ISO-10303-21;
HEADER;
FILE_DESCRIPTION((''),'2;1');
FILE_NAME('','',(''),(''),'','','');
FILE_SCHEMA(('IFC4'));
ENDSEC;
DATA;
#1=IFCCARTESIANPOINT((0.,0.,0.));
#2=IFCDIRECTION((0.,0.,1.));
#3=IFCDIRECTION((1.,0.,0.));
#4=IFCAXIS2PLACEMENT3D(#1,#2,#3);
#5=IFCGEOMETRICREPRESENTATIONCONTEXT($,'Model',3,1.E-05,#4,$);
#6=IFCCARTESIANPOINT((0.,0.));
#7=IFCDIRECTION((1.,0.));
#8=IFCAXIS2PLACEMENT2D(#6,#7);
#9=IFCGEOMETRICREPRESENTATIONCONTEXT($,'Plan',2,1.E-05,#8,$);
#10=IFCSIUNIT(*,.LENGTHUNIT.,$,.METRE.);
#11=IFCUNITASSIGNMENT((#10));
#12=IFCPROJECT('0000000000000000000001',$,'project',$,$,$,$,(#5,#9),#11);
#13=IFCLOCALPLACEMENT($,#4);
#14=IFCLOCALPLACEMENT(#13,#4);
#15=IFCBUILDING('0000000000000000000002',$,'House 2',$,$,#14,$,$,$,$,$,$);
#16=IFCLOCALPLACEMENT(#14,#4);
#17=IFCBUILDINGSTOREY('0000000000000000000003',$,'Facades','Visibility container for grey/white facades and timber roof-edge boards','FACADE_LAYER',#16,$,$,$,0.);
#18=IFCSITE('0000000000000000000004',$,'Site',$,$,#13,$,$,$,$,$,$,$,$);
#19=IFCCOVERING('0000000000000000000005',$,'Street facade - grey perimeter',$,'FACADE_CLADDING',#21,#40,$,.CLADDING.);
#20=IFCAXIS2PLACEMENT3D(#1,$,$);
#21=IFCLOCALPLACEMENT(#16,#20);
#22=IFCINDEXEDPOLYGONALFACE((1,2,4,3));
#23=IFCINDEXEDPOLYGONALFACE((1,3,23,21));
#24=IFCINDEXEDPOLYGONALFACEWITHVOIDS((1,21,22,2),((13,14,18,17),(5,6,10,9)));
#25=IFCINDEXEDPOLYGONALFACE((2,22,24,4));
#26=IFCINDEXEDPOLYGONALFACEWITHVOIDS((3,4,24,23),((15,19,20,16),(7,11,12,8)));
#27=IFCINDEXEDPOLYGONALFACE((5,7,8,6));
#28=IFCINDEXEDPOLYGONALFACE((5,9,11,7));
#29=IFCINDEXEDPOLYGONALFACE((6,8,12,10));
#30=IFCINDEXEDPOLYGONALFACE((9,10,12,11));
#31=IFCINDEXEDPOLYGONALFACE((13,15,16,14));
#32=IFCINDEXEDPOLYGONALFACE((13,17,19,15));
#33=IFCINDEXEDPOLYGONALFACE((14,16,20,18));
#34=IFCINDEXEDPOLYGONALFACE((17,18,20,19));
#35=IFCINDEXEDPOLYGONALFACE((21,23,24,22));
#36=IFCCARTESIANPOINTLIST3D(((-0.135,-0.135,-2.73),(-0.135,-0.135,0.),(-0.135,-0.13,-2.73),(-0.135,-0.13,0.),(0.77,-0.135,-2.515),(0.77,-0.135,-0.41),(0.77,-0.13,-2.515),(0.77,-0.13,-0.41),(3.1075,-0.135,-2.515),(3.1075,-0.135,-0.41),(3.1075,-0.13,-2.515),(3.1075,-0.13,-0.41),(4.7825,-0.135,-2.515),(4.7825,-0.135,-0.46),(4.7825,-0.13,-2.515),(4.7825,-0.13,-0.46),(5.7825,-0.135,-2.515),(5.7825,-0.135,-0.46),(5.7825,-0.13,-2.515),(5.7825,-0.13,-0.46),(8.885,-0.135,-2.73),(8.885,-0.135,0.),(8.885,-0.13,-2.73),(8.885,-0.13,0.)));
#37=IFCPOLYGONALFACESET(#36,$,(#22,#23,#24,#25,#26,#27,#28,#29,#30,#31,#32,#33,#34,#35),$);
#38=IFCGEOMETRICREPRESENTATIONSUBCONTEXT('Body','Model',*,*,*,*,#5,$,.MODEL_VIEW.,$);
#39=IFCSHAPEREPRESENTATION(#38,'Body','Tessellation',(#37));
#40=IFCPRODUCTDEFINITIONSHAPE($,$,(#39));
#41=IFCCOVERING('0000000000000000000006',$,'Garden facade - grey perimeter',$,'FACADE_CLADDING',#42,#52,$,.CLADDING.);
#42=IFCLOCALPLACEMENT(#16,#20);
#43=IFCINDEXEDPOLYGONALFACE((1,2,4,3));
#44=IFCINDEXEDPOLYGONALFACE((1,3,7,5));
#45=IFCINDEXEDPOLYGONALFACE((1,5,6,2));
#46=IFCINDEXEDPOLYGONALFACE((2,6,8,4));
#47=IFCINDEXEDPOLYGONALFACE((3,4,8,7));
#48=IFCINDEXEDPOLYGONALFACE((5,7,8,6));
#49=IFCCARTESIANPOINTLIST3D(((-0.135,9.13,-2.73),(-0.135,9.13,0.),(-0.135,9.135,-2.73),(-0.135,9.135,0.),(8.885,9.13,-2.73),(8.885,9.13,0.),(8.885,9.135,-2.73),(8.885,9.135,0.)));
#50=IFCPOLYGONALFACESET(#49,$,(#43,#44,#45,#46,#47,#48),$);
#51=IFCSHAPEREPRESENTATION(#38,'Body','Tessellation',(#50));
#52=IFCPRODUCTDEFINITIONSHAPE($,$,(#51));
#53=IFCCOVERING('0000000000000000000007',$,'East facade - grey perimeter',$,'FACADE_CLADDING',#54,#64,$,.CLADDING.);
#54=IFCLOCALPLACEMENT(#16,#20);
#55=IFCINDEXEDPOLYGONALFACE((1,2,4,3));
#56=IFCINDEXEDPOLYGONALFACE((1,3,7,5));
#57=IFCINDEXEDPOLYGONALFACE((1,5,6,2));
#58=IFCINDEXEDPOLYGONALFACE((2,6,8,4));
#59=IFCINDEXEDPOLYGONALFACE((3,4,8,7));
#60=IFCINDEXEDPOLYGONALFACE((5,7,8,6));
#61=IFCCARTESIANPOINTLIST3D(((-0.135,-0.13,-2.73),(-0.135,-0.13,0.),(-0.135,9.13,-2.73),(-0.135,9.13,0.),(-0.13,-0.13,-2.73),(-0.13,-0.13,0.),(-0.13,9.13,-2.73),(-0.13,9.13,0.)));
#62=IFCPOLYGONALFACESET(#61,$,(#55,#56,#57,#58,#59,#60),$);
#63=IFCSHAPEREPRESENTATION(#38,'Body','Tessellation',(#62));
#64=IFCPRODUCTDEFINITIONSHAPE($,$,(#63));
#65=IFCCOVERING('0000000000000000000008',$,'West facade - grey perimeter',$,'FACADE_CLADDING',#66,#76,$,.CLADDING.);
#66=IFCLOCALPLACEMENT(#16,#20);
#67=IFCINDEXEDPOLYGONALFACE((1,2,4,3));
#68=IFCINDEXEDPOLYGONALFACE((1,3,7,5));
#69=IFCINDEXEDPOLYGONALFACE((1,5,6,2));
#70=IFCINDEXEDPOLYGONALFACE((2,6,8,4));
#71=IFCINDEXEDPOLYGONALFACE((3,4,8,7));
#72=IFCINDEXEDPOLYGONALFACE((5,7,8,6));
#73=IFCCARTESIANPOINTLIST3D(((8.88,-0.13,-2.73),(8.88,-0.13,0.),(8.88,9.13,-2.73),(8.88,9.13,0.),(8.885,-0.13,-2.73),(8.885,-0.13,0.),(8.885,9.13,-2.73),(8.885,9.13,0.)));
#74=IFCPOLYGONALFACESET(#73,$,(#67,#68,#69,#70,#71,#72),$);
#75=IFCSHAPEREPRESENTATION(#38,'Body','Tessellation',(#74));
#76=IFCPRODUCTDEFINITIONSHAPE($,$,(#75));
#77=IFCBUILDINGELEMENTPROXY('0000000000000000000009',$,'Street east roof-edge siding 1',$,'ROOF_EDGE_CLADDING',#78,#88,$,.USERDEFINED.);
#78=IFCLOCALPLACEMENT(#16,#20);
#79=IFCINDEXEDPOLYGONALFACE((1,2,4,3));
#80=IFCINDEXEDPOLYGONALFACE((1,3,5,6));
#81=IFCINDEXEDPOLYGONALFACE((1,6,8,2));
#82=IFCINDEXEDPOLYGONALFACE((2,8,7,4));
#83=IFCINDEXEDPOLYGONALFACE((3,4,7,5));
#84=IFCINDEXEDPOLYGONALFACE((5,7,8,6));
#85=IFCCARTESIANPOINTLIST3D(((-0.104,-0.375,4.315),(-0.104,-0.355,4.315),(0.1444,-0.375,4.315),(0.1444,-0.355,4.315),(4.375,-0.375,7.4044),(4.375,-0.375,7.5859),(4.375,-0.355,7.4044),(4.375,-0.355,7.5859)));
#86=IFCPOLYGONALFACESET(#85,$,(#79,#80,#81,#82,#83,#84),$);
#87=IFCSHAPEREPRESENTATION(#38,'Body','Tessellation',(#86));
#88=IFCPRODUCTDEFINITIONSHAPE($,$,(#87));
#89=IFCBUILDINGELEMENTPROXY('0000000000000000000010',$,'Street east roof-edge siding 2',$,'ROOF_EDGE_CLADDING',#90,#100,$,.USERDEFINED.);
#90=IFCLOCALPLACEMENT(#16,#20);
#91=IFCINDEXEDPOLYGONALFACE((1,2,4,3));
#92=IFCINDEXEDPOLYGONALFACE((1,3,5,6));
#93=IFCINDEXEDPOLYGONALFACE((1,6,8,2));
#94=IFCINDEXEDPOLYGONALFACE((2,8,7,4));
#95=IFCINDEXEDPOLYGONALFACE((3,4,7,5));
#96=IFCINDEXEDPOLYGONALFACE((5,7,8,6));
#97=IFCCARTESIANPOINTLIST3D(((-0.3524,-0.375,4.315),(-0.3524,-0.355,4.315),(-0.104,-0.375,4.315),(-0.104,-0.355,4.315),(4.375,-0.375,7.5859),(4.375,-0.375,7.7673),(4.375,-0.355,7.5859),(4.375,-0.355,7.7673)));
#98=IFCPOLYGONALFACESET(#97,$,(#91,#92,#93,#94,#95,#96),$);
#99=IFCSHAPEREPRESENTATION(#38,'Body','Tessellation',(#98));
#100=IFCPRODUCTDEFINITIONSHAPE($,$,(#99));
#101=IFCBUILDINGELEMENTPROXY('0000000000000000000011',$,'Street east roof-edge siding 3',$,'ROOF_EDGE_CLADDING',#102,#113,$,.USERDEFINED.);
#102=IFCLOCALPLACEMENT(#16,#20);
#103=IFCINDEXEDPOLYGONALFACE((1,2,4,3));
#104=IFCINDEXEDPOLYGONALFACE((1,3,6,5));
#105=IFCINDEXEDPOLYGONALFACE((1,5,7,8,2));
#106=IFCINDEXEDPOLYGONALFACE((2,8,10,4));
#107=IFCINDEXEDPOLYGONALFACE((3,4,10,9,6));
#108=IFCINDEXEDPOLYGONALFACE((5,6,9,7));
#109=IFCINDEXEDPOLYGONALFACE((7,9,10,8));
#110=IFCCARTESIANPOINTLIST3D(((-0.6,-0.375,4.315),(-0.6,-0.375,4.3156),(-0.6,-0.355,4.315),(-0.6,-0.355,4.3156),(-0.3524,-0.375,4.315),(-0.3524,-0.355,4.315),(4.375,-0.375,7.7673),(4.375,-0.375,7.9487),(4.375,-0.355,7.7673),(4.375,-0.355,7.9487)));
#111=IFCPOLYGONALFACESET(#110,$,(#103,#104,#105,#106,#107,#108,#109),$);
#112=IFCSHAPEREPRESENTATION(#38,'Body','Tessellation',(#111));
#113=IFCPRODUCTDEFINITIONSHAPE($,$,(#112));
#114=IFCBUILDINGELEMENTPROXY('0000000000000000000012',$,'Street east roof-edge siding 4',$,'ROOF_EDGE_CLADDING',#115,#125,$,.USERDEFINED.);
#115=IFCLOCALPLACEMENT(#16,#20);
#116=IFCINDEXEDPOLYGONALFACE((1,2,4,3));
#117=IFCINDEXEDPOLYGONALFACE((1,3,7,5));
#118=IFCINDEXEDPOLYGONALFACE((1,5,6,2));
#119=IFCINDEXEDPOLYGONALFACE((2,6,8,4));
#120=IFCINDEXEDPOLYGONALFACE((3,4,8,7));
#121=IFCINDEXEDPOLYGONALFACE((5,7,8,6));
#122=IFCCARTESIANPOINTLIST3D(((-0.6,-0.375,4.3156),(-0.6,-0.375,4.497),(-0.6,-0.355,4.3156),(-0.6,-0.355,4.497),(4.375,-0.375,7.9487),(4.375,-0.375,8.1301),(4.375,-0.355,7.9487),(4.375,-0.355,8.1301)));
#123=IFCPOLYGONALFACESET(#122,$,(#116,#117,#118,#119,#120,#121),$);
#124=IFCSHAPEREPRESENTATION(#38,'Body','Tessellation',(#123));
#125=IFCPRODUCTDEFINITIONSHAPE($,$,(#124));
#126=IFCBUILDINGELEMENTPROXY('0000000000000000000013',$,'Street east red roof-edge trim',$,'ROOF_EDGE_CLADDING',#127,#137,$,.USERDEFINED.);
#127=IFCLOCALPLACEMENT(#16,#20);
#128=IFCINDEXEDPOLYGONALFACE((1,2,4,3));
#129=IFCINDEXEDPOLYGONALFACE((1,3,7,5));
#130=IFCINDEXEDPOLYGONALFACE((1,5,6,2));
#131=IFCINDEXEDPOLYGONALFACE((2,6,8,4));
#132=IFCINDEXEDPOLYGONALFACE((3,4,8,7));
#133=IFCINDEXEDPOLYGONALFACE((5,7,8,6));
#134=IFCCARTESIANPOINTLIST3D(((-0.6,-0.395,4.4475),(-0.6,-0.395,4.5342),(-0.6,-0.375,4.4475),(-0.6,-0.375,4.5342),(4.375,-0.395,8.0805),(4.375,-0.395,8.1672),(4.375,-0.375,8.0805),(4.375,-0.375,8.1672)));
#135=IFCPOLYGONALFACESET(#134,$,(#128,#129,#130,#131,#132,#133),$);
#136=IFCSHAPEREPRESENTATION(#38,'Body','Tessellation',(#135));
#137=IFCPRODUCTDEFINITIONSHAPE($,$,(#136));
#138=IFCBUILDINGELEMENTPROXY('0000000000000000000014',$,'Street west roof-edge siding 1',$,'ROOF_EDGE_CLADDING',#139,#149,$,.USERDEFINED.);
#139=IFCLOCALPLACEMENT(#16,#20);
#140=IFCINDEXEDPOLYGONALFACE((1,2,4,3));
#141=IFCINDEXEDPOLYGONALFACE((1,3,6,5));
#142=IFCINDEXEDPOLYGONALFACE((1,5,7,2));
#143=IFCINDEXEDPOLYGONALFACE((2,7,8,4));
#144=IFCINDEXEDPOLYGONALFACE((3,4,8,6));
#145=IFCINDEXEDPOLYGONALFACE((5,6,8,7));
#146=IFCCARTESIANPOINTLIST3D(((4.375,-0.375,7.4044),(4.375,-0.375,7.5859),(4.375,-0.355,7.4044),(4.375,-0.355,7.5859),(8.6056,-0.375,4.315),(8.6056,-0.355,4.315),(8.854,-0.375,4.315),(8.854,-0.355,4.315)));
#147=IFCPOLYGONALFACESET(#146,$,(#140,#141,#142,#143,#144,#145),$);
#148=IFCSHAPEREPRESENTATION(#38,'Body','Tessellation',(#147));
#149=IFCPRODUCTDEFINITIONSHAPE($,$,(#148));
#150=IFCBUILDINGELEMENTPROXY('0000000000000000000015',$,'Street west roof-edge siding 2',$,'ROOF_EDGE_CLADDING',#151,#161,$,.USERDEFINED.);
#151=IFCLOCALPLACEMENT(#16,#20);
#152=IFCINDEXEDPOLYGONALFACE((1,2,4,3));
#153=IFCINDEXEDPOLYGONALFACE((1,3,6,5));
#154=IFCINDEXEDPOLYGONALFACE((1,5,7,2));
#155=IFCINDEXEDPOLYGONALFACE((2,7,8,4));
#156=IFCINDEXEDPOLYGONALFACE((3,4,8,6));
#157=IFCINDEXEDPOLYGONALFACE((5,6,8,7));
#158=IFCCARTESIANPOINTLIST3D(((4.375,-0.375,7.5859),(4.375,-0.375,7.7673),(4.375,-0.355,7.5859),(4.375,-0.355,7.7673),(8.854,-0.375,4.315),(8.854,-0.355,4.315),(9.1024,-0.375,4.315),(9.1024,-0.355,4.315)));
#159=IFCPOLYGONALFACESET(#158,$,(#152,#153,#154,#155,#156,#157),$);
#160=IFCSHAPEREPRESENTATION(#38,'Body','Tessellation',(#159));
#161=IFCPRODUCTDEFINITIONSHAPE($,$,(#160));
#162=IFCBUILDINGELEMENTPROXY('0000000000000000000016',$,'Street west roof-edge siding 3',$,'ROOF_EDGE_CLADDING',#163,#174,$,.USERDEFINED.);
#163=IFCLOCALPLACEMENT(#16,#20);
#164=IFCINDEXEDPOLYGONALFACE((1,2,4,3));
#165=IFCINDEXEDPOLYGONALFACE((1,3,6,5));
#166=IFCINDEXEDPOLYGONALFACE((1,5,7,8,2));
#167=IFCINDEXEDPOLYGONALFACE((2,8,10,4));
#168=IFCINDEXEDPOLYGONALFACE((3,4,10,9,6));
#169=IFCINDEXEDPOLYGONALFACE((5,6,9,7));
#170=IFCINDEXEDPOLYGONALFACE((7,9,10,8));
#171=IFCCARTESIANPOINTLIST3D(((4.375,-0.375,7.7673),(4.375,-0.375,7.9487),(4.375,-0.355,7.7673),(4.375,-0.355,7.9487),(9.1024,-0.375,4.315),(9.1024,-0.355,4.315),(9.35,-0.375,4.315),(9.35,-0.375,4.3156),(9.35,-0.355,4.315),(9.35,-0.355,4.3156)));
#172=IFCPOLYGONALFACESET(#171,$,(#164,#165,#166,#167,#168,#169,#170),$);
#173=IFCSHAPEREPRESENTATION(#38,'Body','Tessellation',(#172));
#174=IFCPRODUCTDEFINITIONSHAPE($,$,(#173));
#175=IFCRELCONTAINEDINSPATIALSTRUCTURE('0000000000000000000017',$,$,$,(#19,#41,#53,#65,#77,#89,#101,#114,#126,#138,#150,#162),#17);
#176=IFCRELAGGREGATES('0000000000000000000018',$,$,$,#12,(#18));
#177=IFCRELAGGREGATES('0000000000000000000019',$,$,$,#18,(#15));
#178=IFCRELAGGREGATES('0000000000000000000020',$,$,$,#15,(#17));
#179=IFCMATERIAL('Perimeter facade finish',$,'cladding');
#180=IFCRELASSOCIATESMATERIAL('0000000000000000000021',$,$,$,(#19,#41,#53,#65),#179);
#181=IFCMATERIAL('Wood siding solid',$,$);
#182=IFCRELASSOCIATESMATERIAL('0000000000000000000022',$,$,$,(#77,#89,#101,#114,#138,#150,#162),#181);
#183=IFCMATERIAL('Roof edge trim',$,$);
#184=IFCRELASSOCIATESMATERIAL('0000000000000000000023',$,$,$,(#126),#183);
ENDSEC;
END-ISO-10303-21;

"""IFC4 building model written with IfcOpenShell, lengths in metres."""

from ifc_helpers import new_model, si_unit, frame, origin_with_axes, origin_2d_with_axis, place, context, subcontext, project, spatial, line, indexed_curve, outline, extrude, material, element, save


model = new_model("IFC4")

# Units and contexts
model_context = context("Model", 3, precision=1e-05, world=origin_with_axes())
plan_context = context("Plan", 2, precision=1e-05, world=origin_2d_with_axis())
body_context = subcontext(model_context, "Body", "Model", "MODEL_VIEW")
ifc_project = project(units=[si_unit("LENGTHUNIT", "METRE")], contexts=[model_context, plan_context])

# Site, building, storey
site_placement = place(None, origin_with_axes())
site = spatial("IfcSite", under=ifc_project, at=site_placement, Name="Site")
building_placement = place(site_placement, origin_with_axes())
building = spatial("IfcBuilding", under=site, at=building_placement, Name="House 2")
storey_placement = place(building_placement, origin_with_axes())
storey = spatial("IfcBuildingStorey", under=building, at=storey_placement, Name="Facades", Description="Visibility container for grey/white facades and timber roof-edge boards", ObjectType="FACADE_LAYER", Elevation=0.0)

# Covering, openings
ifc_material_1 = material(Name="Perimeter facade finish", Category="cladding")
covering_1_placement = place(storey_placement, frame((-0.135, 0.12, -2.73), z_axis=(0.0, 0.0, 1.0), x_axis=(1.0, 0.0, 0.0)))
covering_1 = element("IfcCovering", 1, at=covering_1_placement, inside=storey, material=ifc_material_1, Name="Street facade - grey perimeter", ObjectType="FACADE_CLADDING", PredefinedType="CLADDING", context=body_context, shape_type="SweptSolid", body=[
    extrude(outline(indexed_curve([(0.0, 0.0), (0.0, 0.005), (9.02, 0.005), (9.02, 0.0), (0.0, 0.0)], self_intersect=False)), frame((0.0, -0.255, 0.0), z_axis=(0.0, 0.0, 1.0), x_axis=(1.0, 0.0, 0.0)), (0.0, 0.0, 1.0), 2.73),
])
opening_1_placement = place(covering_1_placement, frame((4.9175, 0.0, 0.215), z_axis=(0.0, 0.0, 1.0), x_axis=(1.0, 0.0, 0.0)))
element("IfcOpeningElement", 2, at=opening_1_placement, cuts=covering_1, PredefinedType="OPENING", context=body_context, shape_type="SweptSolid", body=[
    extrude(outline(indexed_curve([(0.0, 0.0), (0.0, 0.025), (1.0, 0.025), (1.0, 0.0), (0.0, 0.0)], self_intersect=False)), frame((0.0, -0.265, 0.0), z_axis=(0.0, 0.0, 1.0), x_axis=(1.0, 0.0, 0.0)), (0.0, 0.0, 1.0), 2.055),
])
opening_2_placement = place(covering_1_placement, frame((0.905, 0.0, 0.215), z_axis=(0.0, 0.0, 1.0), x_axis=(1.0, 0.0, 0.0)))
element("IfcOpeningElement", 3, at=opening_2_placement, cuts=covering_1, PredefinedType="OPENING", context=body_context, shape_type="SweptSolid", body=[
    extrude(outline(indexed_curve([(0.0, 0.0), (0.0, 0.025), (2.3375, 0.025), (2.3375, 0.0), (0.0, 0.0)], self_intersect=False)), frame((0.0, -0.265, 0.0), z_axis=(0.0, 0.0, 1.0), x_axis=(1.0, 0.0, 0.0)), (0.0, 0.0, 1.0), 2.105),
])

# Covering
covering_2_placement = place(storey_placement, frame((8.885, 8.88, -2.73), z_axis=(0.0, 0.0, 1.0), x_axis=(-1.0, 0.0, 0.0)))
element("IfcCovering", 4, at=covering_2_placement, inside=storey, material=ifc_material_1, Name="Garden facade - grey perimeter", ObjectType="FACADE_CLADDING", PredefinedType="CLADDING", context=body_context, shape_type="SweptSolid", body=[
    extrude(outline(indexed_curve([(0.0, 0.0), (0.0, 0.005), (9.02, 0.005), (9.02, 0.0), (0.0, 0.0)], self_intersect=False)), frame((0.0, -0.255, 0.0), z_axis=(0.0, 0.0, 1.0), x_axis=(1.0, 0.0, 0.0)), (0.0, 0.0, 1.0), 2.73),
])

# Coverings
covering_3_placement = place(storey_placement, frame((0.12, 9.13, -2.73), z_axis=(0.0, 0.0, 1.0), x_axis=(0.0, -1.0, 0.0)))
element("IfcCovering", 5, at=covering_3_placement, inside=storey, material=ifc_material_1, Name="East facade - grey perimeter", ObjectType="FACADE_CLADDING", PredefinedType="CLADDING", context=body_context, shape_type="SweptSolid", body=[
    extrude(outline(indexed_curve([(0.0, 0.0), (0.0, 0.005), (9.26, 0.005), (9.26, 0.0), (0.0, 0.0)], self_intersect=False)), frame((0.0, -0.255, 0.0), z_axis=(0.0, 0.0, 1.0), x_axis=(1.0, 0.0, 0.0)), (0.0, 0.0, 1.0), 2.73),
])
covering_4_placement = place(storey_placement, frame((8.63, -0.13, -2.73), z_axis=(0.0, 0.0, 1.0), x_axis=(0.0, 1.0, 0.0)))
element("IfcCovering", 6, at=covering_4_placement, inside=storey, material=ifc_material_1, Name="West facade - grey perimeter", ObjectType="FACADE_CLADDING", PredefinedType="CLADDING", context=body_context, shape_type="SweptSolid", body=[
    extrude(outline(indexed_curve([(0.0, 0.0), (0.0, 0.005), (9.26, 0.005), (9.26, 0.0), (0.0, 0.0)], self_intersect=False)), frame((0.0, -0.255, 0.0), z_axis=(0.0, 0.0, 1.0), x_axis=(1.0, 0.0, 0.0)), (0.0, 0.0, 1.0), 2.73),
])

# Building element proxies
ifc_material_2 = material(Name="Wood siding solid")
proxy_1_placement = place(storey_placement, frame((0.1444, -0.375, 4.315), z_axis=(0.0, 1.0, 0.0), x_axis=(-1.0, 0.0, 0.0)))
element("IfcBuildingElementProxy", 7, at=proxy_1_placement, inside=storey, material=ifc_material_2, Name="Street east roof-edge siding 1", ObjectType="ROOF_EDGE_CLADDING", PredefinedType="USERDEFINED", context=body_context, shape_type="SweptSolid", body=[
    extrude(outline(indexed_curve([(0.0, 0.0), (0.2484, 0.0), (-4.2306, 3.2709), (-4.2306, 3.0894)], segments=[line(1, 2, 3, 4, 1)])), origin_with_axes(), (0.0, 0.0, 1.0), 0.02),
])
proxy_2_placement = place(storey_placement, frame((-0.104, -0.375, 4.315), z_axis=(0.0, 1.0, 0.0), x_axis=(-1.0, 0.0, 0.0)))
element("IfcBuildingElementProxy", 8, at=proxy_2_placement, inside=storey, material=ifc_material_2, Name="Street east roof-edge siding 2", ObjectType="ROOF_EDGE_CLADDING", PredefinedType="USERDEFINED", context=body_context, shape_type="SweptSolid", body=[
    extrude(outline(indexed_curve([(0.0, 0.0), (0.2484, 0.0), (-4.479, 3.4523), (-4.479, 3.2709)], segments=[line(1, 2, 3, 4, 1)])), origin_with_axes(), (0.0, 0.0, 1.0), 0.02),
])
proxy_3_placement = place(storey_placement, frame((-0.3524, -0.375, 4.315), z_axis=(0.0, 1.0, 0.0), x_axis=(-1.0, 0.0, 0.0)))
element("IfcBuildingElementProxy", 9, at=proxy_3_placement, inside=storey, material=ifc_material_2, Name="Street east roof-edge siding 3", ObjectType="ROOF_EDGE_CLADDING", PredefinedType="USERDEFINED", context=body_context, shape_type="SweptSolid", body=[
    extrude(outline(indexed_curve([(0.0, 0.0), (0.2476, 0.0), (0.2476, 0.0006), (-4.7274, 3.6337), (-4.7274, 3.4523)], segments=[line(1, 2, 3, 4, 5, 1)])), origin_with_axes(), (0.0, 0.0, 1.0), 0.02),
])
proxy_4_placement = place(storey_placement, frame((-0.6, -0.375, 4.3156), z_axis=(0.0, 1.0, 0.0), x_axis=(0.0, 0.0, 1.0)))
element("IfcBuildingElementProxy", 10, at=proxy_4_placement, inside=storey, material=ifc_material_2, Name="Street east roof-edge siding 4", ObjectType="ROOF_EDGE_CLADDING", PredefinedType="USERDEFINED", context=body_context, shape_type="SweptSolid", body=[
    extrude(outline(indexed_curve([(0.0, 0.0), (0.1814, 0.0), (3.8145, 4.975), (3.6331, 4.975)], segments=[line(1, 2, 3, 4, 1)])), origin_with_axes(), (0.0, 0.0, 1.0), 0.02),
])
ifc_material_3 = material(Name="Roof edge trim")
proxy_5_placement = place(storey_placement, frame((4.375, -0.375, 8.0805), z_axis=(0.0, -1.0, 0.0), x_axis=(0.0, 0.0, 1.0)))
element("IfcBuildingElementProxy", 11, at=proxy_5_placement, inside=storey, material=ifc_material_3, Name="Street east red roof-edge trim", ObjectType="ROOF_EDGE_CLADDING", PredefinedType="USERDEFINED", context=body_context, shape_type="SweptSolid", body=[
    extrude(outline(indexed_curve([(0.0, 0.0), (0.0867, 0.0), (-3.5464, 4.975), (-3.6331, 4.975)], segments=[line(1, 2, 3, 4, 1)])), origin_with_axes(), (0.0, 0.0, 1.0), 0.02),
])
proxy_6_placement = place(storey_placement, frame((4.375, -0.375, 7.4044), z_axis=(0.0, 1.0, 0.0), x_axis=(0.0, 0.0, 1.0)))
element("IfcBuildingElementProxy", 12, at=proxy_6_placement, inside=storey, material=ifc_material_2, Name="Street west roof-edge siding 1", ObjectType="ROOF_EDGE_CLADDING", PredefinedType="USERDEFINED", context=body_context, shape_type="SweptSolid", body=[
    extrude(outline(indexed_curve([(0.0, 0.0), (0.1814, 0.0), (-3.0894, 4.479), (-3.0894, 4.2306)], segments=[line(1, 2, 3, 4, 1)])), origin_with_axes(), (0.0, 0.0, 1.0), 0.02),
])
proxy_7_placement = place(storey_placement, frame((4.375, -0.375, 7.5859), z_axis=(0.0, 1.0, 0.0), x_axis=(0.0, 0.0, 1.0)))
element("IfcBuildingElementProxy", 13, at=proxy_7_placement, inside=storey, material=ifc_material_2, Name="Street west roof-edge siding 2", ObjectType="ROOF_EDGE_CLADDING", PredefinedType="USERDEFINED", context=body_context, shape_type="SweptSolid", body=[
    extrude(outline(indexed_curve([(0.0, 0.0), (0.1814, 0.0), (-3.2709, 4.7274), (-3.2709, 4.479)], segments=[line(1, 2, 3, 4, 1)])), origin_with_axes(), (0.0, 0.0, 1.0), 0.02),
])
proxy_8_placement = place(storey_placement, frame((4.375, -0.375, 7.7673), z_axis=(0.0, 1.0, 0.0), x_axis=(0.0, 0.0, 1.0)))
element("IfcBuildingElementProxy", 14, at=proxy_8_placement, inside=storey, material=ifc_material_2, Name="Street west roof-edge siding 3", ObjectType="ROOF_EDGE_CLADDING", PredefinedType="USERDEFINED", context=body_context, shape_type="SweptSolid", body=[
    extrude(outline(indexed_curve([(0.0, 0.0), (0.1814, 0.0), (-3.4517, 4.975), (-3.4523, 4.975), (-3.4523, 4.7274)], segments=[line(1, 2, 3, 4, 5, 1)])), origin_with_axes(), (0.0, 0.0, 1.0), 0.02),
])

save(model, "model.ifc")
